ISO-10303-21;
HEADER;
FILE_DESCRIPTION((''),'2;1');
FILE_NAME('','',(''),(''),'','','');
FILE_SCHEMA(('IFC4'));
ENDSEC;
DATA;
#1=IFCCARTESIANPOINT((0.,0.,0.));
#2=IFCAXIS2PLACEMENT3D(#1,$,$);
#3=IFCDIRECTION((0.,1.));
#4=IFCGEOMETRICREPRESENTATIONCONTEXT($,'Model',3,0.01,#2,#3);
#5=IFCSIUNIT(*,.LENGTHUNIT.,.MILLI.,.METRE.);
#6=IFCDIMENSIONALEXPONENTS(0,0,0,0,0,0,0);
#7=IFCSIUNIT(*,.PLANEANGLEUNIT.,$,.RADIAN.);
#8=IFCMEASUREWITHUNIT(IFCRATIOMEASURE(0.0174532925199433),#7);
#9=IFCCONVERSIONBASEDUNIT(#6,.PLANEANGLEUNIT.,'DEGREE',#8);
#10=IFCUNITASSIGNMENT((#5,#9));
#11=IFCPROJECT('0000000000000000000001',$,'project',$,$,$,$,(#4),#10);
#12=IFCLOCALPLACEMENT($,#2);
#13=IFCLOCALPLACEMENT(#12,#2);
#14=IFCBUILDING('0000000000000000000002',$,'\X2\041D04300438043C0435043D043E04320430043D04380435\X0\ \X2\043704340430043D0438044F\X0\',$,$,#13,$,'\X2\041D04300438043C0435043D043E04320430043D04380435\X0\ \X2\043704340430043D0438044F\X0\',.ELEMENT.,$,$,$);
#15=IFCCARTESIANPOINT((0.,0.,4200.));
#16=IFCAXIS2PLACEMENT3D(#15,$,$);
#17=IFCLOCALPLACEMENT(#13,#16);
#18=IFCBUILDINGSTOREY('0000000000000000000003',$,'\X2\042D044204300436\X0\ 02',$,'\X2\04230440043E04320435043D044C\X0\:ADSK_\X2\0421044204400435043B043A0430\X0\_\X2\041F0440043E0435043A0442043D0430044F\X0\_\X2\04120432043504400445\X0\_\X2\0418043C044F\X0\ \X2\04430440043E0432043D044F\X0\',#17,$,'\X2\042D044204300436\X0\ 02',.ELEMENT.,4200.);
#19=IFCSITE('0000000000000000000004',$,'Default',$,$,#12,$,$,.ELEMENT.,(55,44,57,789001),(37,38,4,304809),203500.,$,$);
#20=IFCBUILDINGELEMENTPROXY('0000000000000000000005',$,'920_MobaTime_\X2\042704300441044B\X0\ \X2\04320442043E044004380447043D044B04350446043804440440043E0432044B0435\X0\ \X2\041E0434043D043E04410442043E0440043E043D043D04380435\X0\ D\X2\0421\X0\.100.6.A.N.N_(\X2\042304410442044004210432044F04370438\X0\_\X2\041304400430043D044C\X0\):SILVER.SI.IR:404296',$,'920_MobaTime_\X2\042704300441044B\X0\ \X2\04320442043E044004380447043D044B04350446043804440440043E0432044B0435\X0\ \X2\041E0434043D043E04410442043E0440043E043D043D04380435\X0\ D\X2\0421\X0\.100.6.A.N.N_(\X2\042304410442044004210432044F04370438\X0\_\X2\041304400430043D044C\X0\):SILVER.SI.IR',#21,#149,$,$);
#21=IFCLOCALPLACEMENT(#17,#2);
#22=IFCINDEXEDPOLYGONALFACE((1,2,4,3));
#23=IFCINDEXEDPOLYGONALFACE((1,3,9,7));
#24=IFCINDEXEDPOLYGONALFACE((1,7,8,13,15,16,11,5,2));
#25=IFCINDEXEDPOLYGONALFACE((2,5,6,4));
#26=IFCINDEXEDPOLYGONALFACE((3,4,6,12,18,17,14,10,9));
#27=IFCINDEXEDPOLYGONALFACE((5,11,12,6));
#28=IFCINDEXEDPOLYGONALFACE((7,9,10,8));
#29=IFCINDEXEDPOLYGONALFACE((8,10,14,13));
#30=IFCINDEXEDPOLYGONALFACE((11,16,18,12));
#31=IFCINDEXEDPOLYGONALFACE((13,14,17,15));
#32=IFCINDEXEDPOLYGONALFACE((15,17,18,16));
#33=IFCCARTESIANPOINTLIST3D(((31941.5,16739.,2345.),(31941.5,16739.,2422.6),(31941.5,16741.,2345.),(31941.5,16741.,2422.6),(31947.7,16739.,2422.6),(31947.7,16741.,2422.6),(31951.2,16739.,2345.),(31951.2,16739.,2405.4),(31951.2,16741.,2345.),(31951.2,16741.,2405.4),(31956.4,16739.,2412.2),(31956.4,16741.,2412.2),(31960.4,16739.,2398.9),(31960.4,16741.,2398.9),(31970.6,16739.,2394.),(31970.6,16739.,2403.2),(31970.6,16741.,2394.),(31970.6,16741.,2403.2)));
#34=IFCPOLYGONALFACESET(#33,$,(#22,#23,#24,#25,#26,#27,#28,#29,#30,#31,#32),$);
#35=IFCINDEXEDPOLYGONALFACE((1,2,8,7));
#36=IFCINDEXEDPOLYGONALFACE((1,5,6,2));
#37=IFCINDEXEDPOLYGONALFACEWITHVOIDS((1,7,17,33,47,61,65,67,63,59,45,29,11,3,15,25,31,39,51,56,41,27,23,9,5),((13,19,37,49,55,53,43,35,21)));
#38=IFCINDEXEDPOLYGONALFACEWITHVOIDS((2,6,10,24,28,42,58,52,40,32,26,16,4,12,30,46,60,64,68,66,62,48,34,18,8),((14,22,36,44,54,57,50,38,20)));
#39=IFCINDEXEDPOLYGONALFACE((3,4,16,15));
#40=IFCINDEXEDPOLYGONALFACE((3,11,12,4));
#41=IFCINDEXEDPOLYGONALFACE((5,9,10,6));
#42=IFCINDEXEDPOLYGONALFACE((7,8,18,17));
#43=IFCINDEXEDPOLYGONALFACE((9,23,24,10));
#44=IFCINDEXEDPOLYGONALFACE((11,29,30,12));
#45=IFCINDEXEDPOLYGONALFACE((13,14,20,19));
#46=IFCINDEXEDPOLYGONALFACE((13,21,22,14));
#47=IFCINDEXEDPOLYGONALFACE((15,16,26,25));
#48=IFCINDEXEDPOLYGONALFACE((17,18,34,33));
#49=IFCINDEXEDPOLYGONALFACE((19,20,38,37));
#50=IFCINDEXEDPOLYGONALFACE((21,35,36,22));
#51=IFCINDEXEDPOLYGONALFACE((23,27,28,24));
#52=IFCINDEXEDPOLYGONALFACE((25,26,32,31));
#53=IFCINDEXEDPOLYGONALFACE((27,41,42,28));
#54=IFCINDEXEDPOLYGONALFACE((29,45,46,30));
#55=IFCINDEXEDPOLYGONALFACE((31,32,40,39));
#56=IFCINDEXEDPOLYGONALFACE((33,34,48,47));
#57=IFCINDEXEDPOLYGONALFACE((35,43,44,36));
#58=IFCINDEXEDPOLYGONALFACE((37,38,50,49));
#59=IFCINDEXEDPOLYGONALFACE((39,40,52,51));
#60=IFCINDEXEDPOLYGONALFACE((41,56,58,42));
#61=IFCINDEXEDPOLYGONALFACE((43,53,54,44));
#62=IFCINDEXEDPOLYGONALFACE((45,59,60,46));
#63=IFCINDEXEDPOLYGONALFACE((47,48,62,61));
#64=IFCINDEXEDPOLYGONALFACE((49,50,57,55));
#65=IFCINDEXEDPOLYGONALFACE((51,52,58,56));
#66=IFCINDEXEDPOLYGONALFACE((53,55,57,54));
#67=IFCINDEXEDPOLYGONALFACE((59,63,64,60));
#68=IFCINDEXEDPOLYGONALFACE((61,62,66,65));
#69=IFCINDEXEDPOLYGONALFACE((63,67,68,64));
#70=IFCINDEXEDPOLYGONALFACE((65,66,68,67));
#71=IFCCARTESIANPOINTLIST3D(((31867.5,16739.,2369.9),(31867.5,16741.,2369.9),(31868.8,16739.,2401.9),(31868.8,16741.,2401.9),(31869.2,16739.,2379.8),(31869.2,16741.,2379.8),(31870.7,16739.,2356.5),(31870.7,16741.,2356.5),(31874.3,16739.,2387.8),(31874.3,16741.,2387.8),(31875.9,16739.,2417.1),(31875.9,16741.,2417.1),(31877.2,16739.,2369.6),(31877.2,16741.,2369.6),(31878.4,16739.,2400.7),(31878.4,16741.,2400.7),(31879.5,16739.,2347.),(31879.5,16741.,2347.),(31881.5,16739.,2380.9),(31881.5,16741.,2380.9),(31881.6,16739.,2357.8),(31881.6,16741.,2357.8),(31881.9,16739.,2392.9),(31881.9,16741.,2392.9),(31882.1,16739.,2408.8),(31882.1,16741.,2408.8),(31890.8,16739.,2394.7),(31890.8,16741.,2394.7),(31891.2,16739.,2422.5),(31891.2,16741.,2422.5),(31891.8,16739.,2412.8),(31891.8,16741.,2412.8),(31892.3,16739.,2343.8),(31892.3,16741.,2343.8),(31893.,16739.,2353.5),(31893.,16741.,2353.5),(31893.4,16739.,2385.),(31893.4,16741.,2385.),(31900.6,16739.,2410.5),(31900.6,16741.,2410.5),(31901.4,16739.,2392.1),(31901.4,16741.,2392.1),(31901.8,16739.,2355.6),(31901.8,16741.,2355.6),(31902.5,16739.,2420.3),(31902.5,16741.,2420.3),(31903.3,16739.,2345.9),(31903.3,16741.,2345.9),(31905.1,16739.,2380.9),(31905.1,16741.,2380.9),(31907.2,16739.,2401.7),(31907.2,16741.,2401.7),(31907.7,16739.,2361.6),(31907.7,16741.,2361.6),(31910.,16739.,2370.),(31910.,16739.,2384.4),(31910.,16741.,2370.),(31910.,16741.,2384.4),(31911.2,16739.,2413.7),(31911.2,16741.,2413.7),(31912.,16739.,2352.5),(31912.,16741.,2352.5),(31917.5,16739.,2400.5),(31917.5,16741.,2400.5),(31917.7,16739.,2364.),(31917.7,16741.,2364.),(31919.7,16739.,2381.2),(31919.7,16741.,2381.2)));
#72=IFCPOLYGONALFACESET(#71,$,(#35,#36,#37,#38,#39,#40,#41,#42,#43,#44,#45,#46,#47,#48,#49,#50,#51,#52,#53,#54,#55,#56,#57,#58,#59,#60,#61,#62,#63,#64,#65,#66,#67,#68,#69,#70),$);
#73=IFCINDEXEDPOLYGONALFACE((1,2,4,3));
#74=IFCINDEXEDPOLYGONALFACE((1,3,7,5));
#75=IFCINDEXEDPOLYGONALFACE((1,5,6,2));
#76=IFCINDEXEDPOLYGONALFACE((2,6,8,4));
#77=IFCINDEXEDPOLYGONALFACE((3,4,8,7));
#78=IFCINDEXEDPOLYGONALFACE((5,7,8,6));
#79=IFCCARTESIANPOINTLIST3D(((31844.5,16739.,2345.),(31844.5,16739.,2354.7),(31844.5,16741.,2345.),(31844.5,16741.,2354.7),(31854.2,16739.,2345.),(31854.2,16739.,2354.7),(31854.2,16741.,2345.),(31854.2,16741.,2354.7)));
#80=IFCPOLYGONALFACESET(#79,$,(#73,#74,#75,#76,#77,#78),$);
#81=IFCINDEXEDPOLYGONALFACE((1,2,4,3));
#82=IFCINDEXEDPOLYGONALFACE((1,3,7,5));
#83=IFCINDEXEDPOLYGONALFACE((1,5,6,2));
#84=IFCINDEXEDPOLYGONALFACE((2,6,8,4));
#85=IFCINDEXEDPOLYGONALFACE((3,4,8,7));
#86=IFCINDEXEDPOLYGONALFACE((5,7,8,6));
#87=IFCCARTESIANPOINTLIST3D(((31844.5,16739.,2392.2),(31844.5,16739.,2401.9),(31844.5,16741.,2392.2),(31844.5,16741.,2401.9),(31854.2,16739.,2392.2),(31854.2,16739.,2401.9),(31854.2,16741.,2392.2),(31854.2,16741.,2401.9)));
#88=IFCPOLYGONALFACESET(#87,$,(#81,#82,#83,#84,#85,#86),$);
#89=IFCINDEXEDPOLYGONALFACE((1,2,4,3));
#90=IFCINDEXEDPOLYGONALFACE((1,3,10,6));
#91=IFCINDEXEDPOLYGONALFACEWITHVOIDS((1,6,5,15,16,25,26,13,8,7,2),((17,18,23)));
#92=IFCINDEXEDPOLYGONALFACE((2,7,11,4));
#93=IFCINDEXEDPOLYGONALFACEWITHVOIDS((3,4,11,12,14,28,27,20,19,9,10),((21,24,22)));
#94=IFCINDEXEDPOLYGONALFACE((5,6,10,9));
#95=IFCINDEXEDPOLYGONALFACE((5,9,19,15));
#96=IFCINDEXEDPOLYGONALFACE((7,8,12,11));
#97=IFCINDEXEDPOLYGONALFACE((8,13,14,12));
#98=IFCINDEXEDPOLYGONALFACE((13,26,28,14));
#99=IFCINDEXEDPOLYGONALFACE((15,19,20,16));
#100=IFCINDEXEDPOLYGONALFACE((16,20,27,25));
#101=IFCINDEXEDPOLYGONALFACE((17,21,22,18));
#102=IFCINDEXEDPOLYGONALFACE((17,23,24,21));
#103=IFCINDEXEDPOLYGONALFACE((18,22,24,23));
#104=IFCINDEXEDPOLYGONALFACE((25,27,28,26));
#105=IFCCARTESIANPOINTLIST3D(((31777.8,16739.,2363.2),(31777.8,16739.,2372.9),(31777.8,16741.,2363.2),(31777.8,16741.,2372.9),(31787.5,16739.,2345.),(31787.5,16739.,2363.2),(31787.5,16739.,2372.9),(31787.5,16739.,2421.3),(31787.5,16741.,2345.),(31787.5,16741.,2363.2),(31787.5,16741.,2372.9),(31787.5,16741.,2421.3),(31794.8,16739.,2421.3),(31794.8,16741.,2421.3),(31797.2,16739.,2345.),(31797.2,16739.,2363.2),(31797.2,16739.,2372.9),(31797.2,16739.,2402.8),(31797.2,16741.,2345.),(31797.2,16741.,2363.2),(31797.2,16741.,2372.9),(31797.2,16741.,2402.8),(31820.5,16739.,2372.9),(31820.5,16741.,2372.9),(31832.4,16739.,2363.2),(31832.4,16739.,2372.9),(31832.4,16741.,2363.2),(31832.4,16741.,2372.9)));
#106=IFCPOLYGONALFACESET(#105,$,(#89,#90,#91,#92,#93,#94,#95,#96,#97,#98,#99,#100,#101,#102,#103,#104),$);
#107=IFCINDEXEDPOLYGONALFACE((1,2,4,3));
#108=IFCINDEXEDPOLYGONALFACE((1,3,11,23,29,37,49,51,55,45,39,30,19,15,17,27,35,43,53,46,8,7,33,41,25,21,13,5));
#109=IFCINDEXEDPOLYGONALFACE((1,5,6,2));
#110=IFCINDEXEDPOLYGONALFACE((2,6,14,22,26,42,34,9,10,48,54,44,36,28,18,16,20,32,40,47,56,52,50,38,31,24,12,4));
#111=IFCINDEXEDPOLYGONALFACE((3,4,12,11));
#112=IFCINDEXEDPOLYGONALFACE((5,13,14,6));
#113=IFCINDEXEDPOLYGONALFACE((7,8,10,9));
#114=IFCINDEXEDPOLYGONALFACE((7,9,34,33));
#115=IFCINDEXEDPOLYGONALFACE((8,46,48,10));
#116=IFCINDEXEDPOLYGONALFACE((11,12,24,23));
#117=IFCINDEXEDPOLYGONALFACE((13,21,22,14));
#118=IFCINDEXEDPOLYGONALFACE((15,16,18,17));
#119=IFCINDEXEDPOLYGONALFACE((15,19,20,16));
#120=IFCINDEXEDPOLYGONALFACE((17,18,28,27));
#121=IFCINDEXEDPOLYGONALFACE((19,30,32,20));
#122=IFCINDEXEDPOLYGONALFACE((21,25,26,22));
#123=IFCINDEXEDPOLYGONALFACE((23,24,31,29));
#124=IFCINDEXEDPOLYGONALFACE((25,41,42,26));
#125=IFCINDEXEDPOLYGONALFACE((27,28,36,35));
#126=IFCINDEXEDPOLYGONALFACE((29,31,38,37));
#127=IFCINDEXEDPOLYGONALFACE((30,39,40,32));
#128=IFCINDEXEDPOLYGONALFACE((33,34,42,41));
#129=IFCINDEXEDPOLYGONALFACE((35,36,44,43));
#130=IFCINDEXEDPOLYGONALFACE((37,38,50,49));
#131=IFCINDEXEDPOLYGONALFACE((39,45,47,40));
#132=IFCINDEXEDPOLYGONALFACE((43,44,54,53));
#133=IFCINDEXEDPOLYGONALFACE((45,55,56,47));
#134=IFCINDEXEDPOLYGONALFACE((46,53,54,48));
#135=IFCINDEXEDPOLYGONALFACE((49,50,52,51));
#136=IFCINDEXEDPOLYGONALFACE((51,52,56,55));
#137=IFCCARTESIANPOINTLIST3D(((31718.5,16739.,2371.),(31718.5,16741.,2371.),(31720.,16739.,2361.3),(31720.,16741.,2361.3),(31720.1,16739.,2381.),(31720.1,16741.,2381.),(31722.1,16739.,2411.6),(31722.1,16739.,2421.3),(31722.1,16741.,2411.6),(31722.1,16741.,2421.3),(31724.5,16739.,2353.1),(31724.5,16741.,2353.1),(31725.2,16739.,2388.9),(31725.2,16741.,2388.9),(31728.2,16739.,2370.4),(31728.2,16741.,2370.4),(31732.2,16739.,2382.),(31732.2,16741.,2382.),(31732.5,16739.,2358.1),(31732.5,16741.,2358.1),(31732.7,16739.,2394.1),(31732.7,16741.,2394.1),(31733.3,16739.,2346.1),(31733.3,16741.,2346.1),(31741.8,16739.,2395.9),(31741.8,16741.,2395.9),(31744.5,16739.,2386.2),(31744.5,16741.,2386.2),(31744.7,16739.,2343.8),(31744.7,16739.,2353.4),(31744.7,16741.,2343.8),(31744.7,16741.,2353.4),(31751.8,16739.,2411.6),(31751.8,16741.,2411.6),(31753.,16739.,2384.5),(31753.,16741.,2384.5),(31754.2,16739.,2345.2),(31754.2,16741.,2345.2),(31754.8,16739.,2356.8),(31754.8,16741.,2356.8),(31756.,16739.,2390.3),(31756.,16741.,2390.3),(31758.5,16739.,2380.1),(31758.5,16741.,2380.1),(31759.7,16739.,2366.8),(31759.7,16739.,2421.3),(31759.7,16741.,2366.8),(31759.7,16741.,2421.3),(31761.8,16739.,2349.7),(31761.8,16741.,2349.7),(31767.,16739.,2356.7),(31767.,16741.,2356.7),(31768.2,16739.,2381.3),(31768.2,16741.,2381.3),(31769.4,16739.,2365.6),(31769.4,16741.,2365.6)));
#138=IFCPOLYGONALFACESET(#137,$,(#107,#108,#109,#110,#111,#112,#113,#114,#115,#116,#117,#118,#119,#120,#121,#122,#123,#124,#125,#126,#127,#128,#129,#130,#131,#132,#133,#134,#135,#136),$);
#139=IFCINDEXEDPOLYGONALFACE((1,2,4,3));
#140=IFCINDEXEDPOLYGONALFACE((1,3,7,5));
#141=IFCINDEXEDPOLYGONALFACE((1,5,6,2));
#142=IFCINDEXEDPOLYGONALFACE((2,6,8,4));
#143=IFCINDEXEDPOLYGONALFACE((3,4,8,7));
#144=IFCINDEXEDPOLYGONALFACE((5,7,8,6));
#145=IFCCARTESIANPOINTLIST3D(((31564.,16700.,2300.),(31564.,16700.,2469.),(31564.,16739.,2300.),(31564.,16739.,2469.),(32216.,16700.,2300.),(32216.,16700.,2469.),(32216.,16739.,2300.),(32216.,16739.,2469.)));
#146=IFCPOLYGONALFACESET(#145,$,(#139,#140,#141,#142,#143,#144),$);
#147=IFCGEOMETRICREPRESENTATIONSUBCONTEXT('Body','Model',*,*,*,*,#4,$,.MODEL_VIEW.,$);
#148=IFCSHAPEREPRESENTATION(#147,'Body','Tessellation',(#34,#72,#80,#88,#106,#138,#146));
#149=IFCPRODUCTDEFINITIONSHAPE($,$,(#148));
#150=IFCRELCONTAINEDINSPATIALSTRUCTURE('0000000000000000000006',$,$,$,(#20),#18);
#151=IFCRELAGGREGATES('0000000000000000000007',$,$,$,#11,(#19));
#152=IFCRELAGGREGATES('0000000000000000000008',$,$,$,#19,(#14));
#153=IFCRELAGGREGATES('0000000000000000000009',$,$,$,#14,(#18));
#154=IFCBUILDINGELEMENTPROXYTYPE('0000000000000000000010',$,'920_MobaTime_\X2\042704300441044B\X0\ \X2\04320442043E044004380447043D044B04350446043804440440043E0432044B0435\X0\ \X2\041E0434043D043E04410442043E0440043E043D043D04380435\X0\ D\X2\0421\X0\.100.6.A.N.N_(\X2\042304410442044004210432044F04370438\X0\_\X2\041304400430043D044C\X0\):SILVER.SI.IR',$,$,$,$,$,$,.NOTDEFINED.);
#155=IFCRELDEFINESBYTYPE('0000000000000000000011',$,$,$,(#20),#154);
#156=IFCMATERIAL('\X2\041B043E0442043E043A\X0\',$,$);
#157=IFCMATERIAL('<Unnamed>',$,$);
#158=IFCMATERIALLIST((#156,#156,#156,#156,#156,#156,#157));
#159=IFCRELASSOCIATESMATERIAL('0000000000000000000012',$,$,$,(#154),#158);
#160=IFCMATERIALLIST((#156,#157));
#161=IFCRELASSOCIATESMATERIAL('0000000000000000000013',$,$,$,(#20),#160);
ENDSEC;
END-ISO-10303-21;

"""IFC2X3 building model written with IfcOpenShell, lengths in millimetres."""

from ifc_helpers import new_model, entity, si_unit, converted_unit, direction, frame, origin, origin_2d_with_axis, place, context, subcontext, project, spatial, polyline, rectangle, outline, extrude, source, transform, mapped, material, material_list, type_object, type_shapes, element, save


model = new_model("IFC2X3")

# Units and contexts
model_context = context("Model", 3, precision=0.01, world=origin(), true_north=direction((0.0, 1.0)))
body_context = subcontext(model_context, "Body", "Model", "MODEL_VIEW")
ifc_project = project(units=[si_unit("LENGTHUNIT", "METRE", prefix="MILLI"), converted_unit("PLANEANGLEUNIT", "DEGREE", entity("IfcRatioMeasure", 0.0174532925199433), si_unit("PLANEANGLEUNIT", "RADIAN"), dimensions=[0, 0, 0, 0, 0, 0, 0])], contexts=[model_context])

# Site, building, storey
site_placement = place(None, origin())
site = spatial("IfcSite", under=ifc_project, at=site_placement, Name="Default", CompositionType="ELEMENT", RefLatitude=(55, 44, 57, 789001), RefLongitude=(37, 38, 4, 304809), RefElevation=203500.0)
building_placement = place(site_placement, origin())
building = spatial("IfcBuilding", under=site, at=building_placement, Name="Наименование здания", LongName="Наименование здания", CompositionType="ELEMENT")
storey_placement = place(building_placement, frame((0.0, 0.0, 4200.0)))
storey = spatial("IfcBuildingStorey", under=building, at=storey_placement, Name="Этаж 02", ObjectType="Уровень:ADSK_Стрелка_Проектная_Вверх_Имя уровня", LongName="Этаж 02", CompositionType="ELEMENT", Elevation=4200.0)

# Building element proxy
ifc_material_1 = material(Name="Лоток")
ifc_material_2 = material(Name="<Unnamed>")
ifc_material_list_1 = material_list([ifc_material_1, ifc_material_2])
ifc_material_list_2 = material_list([ifc_material_1, ifc_material_1, ifc_material_1, ifc_material_1, ifc_material_1, ifc_material_1, ifc_material_2])
building_element_proxy_type_1 = type_object("IfcBuildingElementProxyType", Name="920_MobaTime_Часы вторичныецифровые Односторонние DС.100.6.A.N.N_(УстрСвязи_Грань):SILVER.SI.IR", PredefinedType="NOTDEFINED", material=ifc_material_list_2)
shared_shape_1 = source(origin(), body_context, "Body", "SweptSolid", [
    extrude(outline(polyline([(-49.3, -13.1), (28.2, -13.1), (28.2, -6.8), (17.9, 1.8), (8.8, 16.0), (-0.3, 16.0), (4.6, 5.8), (11.1, -3.4), (-49.3, -3.4), (-49.3, -13.1)])), frame((-64.6, 9.8, 39.0), z_axis=(0.0, 0.0, 1.0), x_axis=(0.0, 1.0, 0.0)), (0.0, 0.0, 1.0), 2.0),
    extrude(outline(polyline([(2.2, -27.6), (19.0, -27.6), (30.5, -16.1), (33.3, -4.9), (31.0, 5.8), (21.8, 17.2), (5.2, 27.3), (-11.1, 33.0), (-24.0, 32.7), (-33.6, 27.6), (-40.3, 18.6), (-42.8, 5.7), (-38.0, -6.3), (-27.2, -14.9), (-17.5, -17.7), (-8.2, -16.4), (-0.3, -11.9), (5.1, -4.5), (7.3, 6.2), (4.0, 17.2), (18.4, 7.3), (23.6, -2.4), (22.0, -11.4), (14.2, -18.4), (5.3, -18.3), (2.2, -27.6)]), holes=[polyline([(-9.0, 23.3), (-1.3, 14.3), (-2.5, 2.0), (-11.4, -7.0), (-23.4, -6.0), (-32.2, 2.9), (-31.2, 15.1), (-25.6, 22.1), (-17.5, 24.9), (-9.0, 23.3)])]), frame((-2.7, 3.6, 39.0), z_axis=(0.0, 0.0, 1.0), x_axis=(-0.427649, 0.903945, 0.0)), (0.0, 0.0, 1.0), 2.0),
    extrude(rectangle(XDim=9.7, YDim=9.7, at=origin_2d_with_axis()), frame((40.6, -34.7, 39.0)), (0.0, 0.0, 1.0), 2.0),
    extrude(rectangle(XDim=9.7, YDim=9.7, at=origin_2d_with_axis()), frame((40.6, 12.6, 39.0)), (0.0, 0.0, 1.0), 2.0),
    extrude(outline(polyline([(-0.9, -28.1), (8.8, -28.1), (8.8, -9.9), (18.5, -9.9), (18.5, -0.2), (8.8, -0.2), (8.8, 48.3), (1.5, 48.3), (-36.0, -0.2), (-36.0, -9.9), (-0.9, -9.9), (-0.9, -28.1)]), holes=[polyline([(-0.9, -0.2), (-24.1, -0.2), (-0.9, 29.7), (-0.9, -0.2)])]), frame((93.6, -11.4, 39.0)), (0.0, 0.0, 1.0), 2.0),
    extrude(outline(polyline([(3.3, -28.3), (12.5, -28.3), (20.5, -25.0), (26.8, -18.9), (30.7, -10.0), (31.4, 1.6), (26.9, 11.8), (20.1, 18.4), (11.1, 22.3), (1.0, 23.3), (-7.9, 20.4), (-14.9, 14.5), (-18.9, 6.2), (-17.1, -9.0), (-36.7, 0.5), (-29.1, 29.2), (-38.5, 31.7), (-48.1, -4.6), (-11.6, -23.1), (-8.0, -14.0), (-10.8, -7.6), (-10.2, 1.1), (-3.0, 11.8), (9.2, 12.8), (20.0, 5.5), (21.4, -7.5), (15.5, -16.4), (4.6, -18.6), (3.3, -28.3)])), frame((147.1, -8.5, 39.0), z_axis=(0.0, 0.0, 1.0), x_axis=(0.256974, -0.966418, 0.0)), (0.0, 0.0, 1.0), 2.0),
    extrude(rectangle(XDim=652.0, YDim=169.0, at=origin_2d_with_axis()), frame((0.0, 0.0, 0.0), z_axis=(0.0, 0.0, 1.0), x_axis=(-1.0, 0.0, 0.0)), (0.0, 0.0, 1.0), 39.0),
])
type_shapes(building_element_proxy_type_1, [shared_shape_1])
for number, where, z_axis, x_axis, name in (
    (1, (31890.0, 16700.0, 2384.5), (0.0, 1.0, 0.0), (-1.0, 0.0, 0.0), "920_MobaTime_Часы вторичныецифровые Односторонние DС.100.6.A.N.N_(УстрСвязи_Грань):SILVER.SI.IR:404296"),
):
    element("IfcBuildingElementProxy", number, at=place(storey_placement, frame(where, z_axis=z_axis, x_axis=x_axis)), inside=storey, type_object=building_element_proxy_type_1, material=ifc_material_list_1, Name=name, ObjectType="920_MobaTime_Часы вторичныецифровые Односторонние DС.100.6.A.N.N_(УстрСвязи_Грань):SILVER.SI.IR", context=body_context, shape_type="MappedRepresentation", body=[
        mapped(shared_shape_1, transform((0.0, 0.0, 0.0), scale=1.0)),
    ])

save(model, "model.ifc")
